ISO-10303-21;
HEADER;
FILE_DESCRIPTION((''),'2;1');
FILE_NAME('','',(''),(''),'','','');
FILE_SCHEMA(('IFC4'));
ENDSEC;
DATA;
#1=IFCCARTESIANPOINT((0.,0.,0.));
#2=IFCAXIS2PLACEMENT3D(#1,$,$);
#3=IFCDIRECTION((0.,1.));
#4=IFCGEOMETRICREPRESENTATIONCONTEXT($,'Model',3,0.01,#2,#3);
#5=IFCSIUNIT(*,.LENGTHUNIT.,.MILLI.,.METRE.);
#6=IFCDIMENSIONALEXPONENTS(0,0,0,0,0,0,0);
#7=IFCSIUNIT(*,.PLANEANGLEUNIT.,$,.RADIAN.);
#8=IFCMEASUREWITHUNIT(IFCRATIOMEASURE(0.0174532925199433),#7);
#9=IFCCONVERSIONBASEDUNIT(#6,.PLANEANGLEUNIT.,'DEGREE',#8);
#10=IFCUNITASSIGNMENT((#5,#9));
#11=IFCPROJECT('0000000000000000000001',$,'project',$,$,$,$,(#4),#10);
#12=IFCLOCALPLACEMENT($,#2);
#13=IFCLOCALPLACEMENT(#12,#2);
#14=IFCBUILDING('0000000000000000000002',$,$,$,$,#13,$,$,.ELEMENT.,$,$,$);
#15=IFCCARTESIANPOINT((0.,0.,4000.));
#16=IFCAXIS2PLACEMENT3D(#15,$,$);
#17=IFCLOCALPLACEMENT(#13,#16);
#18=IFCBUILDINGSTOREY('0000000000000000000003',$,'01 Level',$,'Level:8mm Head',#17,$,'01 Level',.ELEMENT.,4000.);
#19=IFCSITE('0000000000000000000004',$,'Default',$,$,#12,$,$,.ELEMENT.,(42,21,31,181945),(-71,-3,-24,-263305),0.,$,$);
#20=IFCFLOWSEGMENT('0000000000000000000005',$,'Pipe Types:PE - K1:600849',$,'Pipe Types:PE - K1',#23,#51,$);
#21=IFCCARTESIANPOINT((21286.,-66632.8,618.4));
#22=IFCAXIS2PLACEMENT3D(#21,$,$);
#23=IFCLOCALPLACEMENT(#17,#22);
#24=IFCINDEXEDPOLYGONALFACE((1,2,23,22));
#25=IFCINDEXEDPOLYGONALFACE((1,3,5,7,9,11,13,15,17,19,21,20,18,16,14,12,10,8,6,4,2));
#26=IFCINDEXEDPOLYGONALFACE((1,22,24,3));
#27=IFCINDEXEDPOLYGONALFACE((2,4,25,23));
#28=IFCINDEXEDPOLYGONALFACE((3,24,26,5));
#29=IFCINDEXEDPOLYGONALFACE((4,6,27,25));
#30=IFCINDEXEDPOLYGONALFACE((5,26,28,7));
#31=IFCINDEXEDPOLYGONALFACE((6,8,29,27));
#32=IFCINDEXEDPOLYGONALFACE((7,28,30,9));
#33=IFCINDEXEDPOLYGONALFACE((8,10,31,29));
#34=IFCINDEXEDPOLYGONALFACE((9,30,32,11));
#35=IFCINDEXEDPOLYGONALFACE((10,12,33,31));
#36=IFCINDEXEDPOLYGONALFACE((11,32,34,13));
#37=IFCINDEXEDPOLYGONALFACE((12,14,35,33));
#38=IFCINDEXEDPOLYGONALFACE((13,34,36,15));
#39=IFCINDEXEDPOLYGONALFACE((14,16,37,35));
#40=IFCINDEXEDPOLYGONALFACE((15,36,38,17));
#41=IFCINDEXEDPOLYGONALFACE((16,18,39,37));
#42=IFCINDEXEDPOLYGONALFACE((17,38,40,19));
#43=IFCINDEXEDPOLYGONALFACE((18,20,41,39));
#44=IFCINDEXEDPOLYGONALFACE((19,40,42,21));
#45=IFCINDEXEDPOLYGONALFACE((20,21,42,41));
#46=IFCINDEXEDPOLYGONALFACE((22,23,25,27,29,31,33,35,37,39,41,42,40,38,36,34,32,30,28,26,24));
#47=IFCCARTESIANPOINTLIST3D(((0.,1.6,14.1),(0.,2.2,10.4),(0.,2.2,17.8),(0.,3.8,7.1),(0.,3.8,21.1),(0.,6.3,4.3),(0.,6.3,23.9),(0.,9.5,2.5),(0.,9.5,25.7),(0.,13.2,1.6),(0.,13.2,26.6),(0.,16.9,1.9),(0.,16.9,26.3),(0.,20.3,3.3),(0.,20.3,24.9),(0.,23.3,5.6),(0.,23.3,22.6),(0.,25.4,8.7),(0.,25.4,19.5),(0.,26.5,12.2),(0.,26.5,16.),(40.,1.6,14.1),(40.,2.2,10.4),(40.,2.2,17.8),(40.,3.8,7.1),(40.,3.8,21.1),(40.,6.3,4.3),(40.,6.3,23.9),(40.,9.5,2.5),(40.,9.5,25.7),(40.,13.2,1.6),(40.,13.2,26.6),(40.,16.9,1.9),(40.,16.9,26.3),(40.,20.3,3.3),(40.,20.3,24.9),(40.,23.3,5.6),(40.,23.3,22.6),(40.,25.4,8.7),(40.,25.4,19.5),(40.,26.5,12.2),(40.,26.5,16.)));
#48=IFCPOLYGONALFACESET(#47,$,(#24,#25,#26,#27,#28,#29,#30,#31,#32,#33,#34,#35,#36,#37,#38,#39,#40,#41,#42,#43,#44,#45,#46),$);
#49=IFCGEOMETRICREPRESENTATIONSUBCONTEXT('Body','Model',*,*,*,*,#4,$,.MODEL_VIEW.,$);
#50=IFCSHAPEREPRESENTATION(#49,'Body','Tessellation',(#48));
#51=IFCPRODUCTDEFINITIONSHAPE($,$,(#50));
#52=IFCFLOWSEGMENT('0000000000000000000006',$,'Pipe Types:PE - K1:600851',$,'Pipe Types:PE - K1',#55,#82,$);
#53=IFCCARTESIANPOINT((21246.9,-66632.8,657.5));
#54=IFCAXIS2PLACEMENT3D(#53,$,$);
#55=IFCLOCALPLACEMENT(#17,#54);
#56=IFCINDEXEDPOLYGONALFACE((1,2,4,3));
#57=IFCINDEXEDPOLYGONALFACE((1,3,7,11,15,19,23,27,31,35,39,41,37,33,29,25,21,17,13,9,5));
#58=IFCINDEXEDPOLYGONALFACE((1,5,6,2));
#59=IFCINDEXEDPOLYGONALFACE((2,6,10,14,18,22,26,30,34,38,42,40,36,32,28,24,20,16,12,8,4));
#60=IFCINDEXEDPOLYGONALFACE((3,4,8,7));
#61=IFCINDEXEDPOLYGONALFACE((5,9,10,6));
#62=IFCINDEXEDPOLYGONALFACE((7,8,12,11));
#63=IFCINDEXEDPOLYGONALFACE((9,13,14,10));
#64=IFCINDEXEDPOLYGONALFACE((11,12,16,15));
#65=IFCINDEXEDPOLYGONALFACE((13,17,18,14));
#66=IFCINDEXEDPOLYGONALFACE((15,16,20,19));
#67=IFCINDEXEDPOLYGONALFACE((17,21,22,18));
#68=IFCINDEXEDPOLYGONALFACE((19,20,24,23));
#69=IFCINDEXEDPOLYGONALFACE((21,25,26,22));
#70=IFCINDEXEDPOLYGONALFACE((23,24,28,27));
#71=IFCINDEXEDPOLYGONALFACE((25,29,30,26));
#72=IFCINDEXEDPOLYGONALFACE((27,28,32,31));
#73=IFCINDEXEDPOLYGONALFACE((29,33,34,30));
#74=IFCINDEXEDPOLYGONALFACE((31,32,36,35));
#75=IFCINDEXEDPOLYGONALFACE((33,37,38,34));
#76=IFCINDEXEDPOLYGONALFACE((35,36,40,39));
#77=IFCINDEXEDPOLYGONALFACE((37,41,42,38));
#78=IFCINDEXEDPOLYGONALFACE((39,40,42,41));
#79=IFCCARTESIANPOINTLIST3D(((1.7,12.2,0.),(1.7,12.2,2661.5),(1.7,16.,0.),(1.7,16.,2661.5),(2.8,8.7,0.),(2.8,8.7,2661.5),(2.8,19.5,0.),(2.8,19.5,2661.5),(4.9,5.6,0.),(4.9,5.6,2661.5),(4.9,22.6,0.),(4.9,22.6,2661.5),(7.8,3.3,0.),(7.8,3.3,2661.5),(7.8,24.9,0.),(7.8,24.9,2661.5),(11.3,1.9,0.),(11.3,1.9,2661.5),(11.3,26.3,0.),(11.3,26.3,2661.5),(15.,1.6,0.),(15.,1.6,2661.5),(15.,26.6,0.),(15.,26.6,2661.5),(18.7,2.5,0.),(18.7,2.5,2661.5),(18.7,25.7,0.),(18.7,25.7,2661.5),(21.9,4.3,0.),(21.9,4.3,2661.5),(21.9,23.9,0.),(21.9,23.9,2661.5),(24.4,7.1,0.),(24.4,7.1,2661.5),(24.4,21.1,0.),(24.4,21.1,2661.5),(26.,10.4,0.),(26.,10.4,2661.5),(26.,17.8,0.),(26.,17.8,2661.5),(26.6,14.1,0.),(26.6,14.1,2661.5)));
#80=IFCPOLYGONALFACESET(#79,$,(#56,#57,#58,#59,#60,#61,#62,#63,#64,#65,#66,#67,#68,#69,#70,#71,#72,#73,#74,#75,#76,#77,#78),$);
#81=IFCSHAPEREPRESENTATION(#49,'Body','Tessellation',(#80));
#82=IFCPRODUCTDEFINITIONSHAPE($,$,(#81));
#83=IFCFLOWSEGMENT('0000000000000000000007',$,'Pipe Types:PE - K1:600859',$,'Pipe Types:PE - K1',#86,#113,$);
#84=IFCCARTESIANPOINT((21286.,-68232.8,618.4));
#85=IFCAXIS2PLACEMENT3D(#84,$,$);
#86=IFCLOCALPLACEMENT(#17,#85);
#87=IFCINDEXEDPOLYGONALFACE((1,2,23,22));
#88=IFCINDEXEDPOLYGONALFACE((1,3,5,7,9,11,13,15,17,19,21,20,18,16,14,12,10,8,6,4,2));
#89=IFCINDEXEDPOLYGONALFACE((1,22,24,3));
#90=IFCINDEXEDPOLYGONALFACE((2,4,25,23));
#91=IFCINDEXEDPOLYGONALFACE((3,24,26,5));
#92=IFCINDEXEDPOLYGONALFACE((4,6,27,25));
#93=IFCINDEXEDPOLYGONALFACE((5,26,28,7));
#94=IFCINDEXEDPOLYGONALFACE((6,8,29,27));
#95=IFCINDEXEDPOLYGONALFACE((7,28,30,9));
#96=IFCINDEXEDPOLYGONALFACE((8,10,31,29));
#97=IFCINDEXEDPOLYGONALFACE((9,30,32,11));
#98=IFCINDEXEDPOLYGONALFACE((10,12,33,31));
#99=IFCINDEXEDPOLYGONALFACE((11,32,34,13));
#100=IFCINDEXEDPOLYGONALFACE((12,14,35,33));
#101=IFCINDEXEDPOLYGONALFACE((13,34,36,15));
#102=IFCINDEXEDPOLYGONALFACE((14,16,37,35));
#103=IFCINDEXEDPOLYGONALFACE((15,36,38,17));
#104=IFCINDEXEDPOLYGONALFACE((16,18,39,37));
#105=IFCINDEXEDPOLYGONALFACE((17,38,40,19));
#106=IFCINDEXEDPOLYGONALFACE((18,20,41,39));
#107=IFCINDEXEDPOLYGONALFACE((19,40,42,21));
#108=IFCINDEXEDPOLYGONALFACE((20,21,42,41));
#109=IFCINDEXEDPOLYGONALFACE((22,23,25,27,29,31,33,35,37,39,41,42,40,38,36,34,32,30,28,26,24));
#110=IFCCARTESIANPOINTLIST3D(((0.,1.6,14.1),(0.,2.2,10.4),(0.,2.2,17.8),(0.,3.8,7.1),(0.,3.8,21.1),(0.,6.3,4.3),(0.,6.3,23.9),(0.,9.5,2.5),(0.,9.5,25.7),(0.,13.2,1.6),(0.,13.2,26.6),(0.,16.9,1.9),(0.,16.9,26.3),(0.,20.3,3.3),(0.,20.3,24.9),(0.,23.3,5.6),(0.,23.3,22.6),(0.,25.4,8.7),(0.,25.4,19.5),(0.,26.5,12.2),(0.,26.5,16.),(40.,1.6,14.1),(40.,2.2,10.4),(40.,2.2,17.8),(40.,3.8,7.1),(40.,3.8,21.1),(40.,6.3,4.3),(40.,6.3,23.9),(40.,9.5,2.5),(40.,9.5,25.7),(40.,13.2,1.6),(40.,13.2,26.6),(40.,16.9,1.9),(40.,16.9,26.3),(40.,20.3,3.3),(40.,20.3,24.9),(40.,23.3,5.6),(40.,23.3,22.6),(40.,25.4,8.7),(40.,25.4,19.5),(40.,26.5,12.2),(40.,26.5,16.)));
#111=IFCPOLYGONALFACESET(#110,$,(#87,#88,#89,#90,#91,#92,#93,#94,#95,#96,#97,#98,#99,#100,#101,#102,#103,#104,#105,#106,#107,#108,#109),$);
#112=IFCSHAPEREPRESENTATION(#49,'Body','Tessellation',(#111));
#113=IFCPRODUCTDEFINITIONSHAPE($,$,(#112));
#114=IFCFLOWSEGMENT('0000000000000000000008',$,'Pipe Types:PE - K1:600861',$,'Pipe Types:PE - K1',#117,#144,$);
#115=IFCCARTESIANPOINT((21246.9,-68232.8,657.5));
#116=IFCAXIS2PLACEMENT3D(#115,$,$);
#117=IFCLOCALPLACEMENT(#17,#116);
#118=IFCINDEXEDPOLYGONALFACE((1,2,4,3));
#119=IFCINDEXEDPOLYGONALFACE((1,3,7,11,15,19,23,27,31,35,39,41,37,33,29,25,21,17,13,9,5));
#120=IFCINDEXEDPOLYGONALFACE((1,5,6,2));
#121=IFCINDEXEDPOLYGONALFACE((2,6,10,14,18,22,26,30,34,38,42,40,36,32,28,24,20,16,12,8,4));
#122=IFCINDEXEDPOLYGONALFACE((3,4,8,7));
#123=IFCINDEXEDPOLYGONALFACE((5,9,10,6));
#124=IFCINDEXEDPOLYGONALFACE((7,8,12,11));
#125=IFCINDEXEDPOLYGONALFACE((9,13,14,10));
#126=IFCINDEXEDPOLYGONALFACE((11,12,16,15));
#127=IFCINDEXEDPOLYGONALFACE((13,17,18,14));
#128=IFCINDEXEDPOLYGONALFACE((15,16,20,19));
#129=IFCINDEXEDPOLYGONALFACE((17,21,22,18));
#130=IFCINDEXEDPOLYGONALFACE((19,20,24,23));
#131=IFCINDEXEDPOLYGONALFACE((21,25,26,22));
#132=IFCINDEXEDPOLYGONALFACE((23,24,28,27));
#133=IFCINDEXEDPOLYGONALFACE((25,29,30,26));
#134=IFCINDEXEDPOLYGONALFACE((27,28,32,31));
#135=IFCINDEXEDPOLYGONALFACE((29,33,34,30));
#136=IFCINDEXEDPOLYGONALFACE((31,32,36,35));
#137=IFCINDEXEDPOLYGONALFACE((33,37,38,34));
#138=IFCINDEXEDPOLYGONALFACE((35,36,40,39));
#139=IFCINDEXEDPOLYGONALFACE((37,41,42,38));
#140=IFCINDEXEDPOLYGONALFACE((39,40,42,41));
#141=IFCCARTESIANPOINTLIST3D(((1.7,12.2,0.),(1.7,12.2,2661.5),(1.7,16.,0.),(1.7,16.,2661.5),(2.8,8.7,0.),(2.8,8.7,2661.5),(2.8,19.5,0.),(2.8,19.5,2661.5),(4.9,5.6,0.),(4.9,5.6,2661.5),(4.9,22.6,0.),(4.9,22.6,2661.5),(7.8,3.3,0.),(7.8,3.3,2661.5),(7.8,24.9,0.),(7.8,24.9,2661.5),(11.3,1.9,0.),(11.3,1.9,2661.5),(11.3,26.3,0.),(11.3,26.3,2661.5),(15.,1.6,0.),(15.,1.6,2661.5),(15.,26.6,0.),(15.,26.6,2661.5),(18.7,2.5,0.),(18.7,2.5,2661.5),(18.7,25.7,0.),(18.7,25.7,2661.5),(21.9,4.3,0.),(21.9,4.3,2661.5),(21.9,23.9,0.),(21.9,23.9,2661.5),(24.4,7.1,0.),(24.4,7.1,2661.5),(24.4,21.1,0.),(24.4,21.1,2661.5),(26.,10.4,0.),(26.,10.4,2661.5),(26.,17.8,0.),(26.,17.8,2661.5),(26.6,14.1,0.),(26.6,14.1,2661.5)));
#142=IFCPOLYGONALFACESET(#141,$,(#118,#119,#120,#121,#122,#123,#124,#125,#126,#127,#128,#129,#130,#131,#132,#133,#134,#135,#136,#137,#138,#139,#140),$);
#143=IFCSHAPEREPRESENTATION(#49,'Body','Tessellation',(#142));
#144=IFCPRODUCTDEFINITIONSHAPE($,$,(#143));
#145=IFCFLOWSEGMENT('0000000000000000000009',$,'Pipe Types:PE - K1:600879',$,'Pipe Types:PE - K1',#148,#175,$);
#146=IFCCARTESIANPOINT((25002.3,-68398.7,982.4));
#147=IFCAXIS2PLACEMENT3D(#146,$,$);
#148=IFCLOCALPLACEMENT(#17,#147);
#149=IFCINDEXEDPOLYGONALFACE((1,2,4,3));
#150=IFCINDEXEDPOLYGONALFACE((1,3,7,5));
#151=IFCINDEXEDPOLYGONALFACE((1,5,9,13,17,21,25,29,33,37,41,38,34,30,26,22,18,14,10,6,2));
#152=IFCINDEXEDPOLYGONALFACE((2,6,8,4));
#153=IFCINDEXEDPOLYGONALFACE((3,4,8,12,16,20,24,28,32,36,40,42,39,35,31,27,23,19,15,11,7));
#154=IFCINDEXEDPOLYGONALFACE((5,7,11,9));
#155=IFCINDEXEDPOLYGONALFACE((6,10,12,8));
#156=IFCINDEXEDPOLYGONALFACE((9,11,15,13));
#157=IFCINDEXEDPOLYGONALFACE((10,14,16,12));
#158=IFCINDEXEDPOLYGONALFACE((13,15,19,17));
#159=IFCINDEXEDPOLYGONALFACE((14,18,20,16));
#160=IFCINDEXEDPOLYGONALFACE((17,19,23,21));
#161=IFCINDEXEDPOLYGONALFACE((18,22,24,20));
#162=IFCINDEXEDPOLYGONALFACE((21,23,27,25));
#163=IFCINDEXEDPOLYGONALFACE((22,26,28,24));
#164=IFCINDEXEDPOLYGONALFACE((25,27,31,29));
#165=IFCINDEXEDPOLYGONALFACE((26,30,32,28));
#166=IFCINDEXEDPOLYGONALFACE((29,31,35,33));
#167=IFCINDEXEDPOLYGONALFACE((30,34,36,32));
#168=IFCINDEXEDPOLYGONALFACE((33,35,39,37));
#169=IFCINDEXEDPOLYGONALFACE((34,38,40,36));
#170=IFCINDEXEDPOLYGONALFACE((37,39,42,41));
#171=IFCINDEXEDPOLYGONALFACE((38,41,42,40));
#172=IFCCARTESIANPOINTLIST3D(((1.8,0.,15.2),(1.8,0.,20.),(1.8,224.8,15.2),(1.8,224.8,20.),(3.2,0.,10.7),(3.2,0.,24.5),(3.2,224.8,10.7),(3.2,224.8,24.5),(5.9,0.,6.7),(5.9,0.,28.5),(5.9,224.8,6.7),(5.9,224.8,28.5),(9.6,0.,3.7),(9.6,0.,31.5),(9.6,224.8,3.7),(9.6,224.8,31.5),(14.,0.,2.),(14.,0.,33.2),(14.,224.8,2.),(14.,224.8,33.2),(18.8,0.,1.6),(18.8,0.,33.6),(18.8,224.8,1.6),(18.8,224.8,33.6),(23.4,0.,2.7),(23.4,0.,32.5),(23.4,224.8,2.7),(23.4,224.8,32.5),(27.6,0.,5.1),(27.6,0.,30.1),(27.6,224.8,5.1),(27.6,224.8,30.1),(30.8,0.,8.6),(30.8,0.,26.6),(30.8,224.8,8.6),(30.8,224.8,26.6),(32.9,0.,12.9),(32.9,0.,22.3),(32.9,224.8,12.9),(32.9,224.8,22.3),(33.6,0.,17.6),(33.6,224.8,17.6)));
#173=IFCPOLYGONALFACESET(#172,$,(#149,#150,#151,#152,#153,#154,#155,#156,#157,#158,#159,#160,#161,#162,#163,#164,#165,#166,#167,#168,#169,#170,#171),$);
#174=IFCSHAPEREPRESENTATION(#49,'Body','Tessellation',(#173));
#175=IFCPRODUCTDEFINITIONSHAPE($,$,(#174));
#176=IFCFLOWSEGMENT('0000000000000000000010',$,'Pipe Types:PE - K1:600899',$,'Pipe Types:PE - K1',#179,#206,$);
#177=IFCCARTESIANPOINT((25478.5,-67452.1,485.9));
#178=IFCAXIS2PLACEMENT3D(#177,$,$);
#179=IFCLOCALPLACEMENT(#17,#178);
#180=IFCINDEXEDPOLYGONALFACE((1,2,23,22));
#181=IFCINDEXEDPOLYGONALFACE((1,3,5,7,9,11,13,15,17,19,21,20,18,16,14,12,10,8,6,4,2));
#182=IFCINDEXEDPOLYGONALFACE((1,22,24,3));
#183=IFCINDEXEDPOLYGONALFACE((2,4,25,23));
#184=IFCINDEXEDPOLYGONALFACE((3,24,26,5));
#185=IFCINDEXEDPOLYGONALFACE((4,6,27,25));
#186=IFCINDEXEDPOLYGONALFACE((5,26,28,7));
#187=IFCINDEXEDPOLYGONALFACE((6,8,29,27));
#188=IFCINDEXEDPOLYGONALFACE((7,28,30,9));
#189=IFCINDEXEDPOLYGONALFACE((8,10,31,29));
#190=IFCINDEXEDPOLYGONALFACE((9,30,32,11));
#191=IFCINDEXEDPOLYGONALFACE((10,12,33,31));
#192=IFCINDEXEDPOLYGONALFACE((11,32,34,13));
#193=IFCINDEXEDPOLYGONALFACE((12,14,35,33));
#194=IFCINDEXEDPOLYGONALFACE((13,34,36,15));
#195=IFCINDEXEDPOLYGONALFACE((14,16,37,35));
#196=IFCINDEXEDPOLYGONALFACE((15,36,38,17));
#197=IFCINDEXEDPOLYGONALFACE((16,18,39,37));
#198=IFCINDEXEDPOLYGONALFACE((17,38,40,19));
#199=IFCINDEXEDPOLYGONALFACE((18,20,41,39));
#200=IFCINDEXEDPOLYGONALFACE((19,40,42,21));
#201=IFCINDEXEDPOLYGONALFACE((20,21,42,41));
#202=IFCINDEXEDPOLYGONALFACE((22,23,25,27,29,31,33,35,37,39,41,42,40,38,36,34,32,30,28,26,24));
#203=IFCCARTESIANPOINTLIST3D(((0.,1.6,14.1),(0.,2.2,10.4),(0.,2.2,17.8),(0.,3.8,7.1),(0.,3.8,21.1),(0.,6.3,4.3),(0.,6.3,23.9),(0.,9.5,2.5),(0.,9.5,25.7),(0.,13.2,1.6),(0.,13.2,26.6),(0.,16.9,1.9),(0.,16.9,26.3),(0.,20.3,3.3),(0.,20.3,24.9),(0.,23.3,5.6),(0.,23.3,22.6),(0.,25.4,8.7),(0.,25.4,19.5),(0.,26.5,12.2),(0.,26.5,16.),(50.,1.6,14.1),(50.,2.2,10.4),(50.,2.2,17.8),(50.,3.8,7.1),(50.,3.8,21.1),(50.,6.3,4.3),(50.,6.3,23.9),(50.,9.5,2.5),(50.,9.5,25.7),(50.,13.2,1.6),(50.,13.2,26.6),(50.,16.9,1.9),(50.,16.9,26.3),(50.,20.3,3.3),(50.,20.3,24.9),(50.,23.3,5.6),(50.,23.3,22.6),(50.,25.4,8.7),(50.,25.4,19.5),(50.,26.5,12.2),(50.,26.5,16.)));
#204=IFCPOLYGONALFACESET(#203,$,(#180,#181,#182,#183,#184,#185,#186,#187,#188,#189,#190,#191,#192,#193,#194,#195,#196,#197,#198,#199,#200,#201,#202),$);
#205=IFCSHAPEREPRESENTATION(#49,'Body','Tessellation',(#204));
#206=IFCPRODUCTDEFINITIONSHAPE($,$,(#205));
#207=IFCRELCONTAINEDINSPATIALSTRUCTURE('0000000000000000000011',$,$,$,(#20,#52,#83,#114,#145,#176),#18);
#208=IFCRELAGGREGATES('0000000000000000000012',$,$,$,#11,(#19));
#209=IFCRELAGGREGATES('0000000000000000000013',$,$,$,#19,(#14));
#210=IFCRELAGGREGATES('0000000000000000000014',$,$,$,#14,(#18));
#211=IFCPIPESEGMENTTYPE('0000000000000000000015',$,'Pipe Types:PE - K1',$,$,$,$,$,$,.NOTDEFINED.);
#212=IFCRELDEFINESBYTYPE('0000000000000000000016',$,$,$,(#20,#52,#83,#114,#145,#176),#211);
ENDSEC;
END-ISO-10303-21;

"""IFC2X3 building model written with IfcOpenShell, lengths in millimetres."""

from ifc_helpers import new_model, entity, si_unit, converted_unit, direction, frame, origin, origin_2d_with_axis, place, context, subcontext, project, spatial, circle, extrude, type_object, element, save


model = new_model("IFC2X3")

# Units and contexts
model_context = context("Model", 3, precision=0.01, world=origin(), true_north=direction((0.0, 1.0)))
body_context = subcontext(model_context, "Body", "Model", "MODEL_VIEW")
ifc_project = project(units=[si_unit("LENGTHUNIT", "METRE", prefix="MILLI"), converted_unit("PLANEANGLEUNIT", "DEGREE", entity("IfcRatioMeasure", 0.0174532925199433), si_unit("PLANEANGLEUNIT", "RADIAN"), dimensions=[0, 0, 0, 0, 0, 0, 0])], contexts=[model_context])

# Site, building, storey
site_placement = place(None, origin())
site = spatial("IfcSite", under=ifc_project, at=site_placement, Name="Default", CompositionType="ELEMENT", RefLatitude=(42, 21, 31, 181945), RefLongitude=(-71, -3, -24, -263305), RefElevation=0.0)
building_placement = place(site_placement, origin())
building = spatial("IfcBuilding", under=site, at=building_placement, CompositionType="ELEMENT")
storey_placement = place(building_placement, frame((0.0, 0.0, 4000.0)))
storey = spatial("IfcBuildingStorey", under=building, at=storey_placement, Name="01 Level", ObjectType="Level:8mm Head", LongName="01 Level", CompositionType="ELEMENT", Elevation=4000.0)

# Flow segments
pipe_segment_type = type_object("IfcPipeSegmentType", Name="Pipe Types:PE - K1", PredefinedType="NOTDEFINED")
flow_segment_1_placement = place(storey_placement, frame((21286.0, -66632.8, 618.4)))
element("IfcFlowSegment", 1, at=flow_segment_1_placement, inside=storey, type_object=pipe_segment_type, Name="Pipe Types:PE - K1:600849", ObjectType="Pipe Types:PE - K1", context=body_context, shape_type="SweptSolid", body=[
    extrude(circle(Radius=12.5, at=origin_2d_with_axis()), frame((0.0, 14.1, 14.1), z_axis=(1.0, 0.0, 0.0), x_axis=(0.0, -1.0, 0.0)), (0.0, 0.0, 1.0), 40.0),
])
flow_segment_2_placement = place(storey_placement, frame((21246.9, -66632.8, 657.5)))
element("IfcFlowSegment", 2, at=flow_segment_2_placement, inside=storey, type_object=pipe_segment_type, Name="Pipe Types:PE - K1:600851", ObjectType="Pipe Types:PE - K1", context=body_context, shape_type="SweptSolid", body=[
    extrude(circle(Radius=12.5, at=origin_2d_with_axis()), frame((14.1, 14.1, 0.0)), (0.0, 0.0, 1.0), 2661.5),
])
flow_segment_3_placement = place(storey_placement, frame((21286.0, -68232.8, 618.4)))
element("IfcFlowSegment", 3, at=flow_segment_3_placement, inside=storey, type_object=pipe_segment_type, Name="Pipe Types:PE - K1:600859", ObjectType="Pipe Types:PE - K1", context=body_context, shape_type="SweptSolid", body=[
    extrude(circle(Radius=12.5, at=origin_2d_with_axis()), frame((0.0, 14.1, 14.1), z_axis=(1.0, 0.0, 0.0), x_axis=(0.0, -1.0, 0.0)), (0.0, 0.0, 1.0), 40.0),
])
flow_segment_4_placement = place(storey_placement, frame((21246.9, -68232.8, 657.5)))
element("IfcFlowSegment", 4, at=flow_segment_4_placement, inside=storey, type_object=pipe_segment_type, Name="Pipe Types:PE - K1:600861", ObjectType="Pipe Types:PE - K1", context=body_context, shape_type="SweptSolid", body=[
    extrude(circle(Radius=12.5, at=origin_2d_with_axis()), frame((14.1, 14.1, 0.0)), (0.0, 0.0, 1.0), 2661.5),
])
flow_segment_5_placement = place(storey_placement, frame((25002.3, -68398.7, 982.4)))
element("IfcFlowSegment", 5, at=flow_segment_5_placement, inside=storey, type_object=pipe_segment_type, Name="Pipe Types:PE - K1:600879", ObjectType="Pipe Types:PE - K1", context=body_context, shape_type="SweptSolid", body=[
    extrude(circle(Radius=16.0, at=origin_2d_with_axis()), frame((17.6, 0.0, 17.6), z_axis=(0.0, 1.0, 0.0), x_axis=(1.0, 0.0, 0.0)), (0.0, 0.0, 1.0), 224.8),
])
flow_segment_6_placement = place(storey_placement, frame((25478.5, -67452.1, 485.9)))
element("IfcFlowSegment", 6, at=flow_segment_6_placement, inside=storey, type_object=pipe_segment_type, Name="Pipe Types:PE - K1:600899", ObjectType="Pipe Types:PE - K1", context=body_context, shape_type="SweptSolid", body=[
    extrude(circle(Radius=12.5, at=origin_2d_with_axis()), frame((0.0, 14.1, 14.1), z_axis=(1.0, 0.0, 0.0), x_axis=(0.0, -1.0, 0.0)), (0.0, 0.0, 1.0), 50.0),
])

save(model, "model.ifc")
